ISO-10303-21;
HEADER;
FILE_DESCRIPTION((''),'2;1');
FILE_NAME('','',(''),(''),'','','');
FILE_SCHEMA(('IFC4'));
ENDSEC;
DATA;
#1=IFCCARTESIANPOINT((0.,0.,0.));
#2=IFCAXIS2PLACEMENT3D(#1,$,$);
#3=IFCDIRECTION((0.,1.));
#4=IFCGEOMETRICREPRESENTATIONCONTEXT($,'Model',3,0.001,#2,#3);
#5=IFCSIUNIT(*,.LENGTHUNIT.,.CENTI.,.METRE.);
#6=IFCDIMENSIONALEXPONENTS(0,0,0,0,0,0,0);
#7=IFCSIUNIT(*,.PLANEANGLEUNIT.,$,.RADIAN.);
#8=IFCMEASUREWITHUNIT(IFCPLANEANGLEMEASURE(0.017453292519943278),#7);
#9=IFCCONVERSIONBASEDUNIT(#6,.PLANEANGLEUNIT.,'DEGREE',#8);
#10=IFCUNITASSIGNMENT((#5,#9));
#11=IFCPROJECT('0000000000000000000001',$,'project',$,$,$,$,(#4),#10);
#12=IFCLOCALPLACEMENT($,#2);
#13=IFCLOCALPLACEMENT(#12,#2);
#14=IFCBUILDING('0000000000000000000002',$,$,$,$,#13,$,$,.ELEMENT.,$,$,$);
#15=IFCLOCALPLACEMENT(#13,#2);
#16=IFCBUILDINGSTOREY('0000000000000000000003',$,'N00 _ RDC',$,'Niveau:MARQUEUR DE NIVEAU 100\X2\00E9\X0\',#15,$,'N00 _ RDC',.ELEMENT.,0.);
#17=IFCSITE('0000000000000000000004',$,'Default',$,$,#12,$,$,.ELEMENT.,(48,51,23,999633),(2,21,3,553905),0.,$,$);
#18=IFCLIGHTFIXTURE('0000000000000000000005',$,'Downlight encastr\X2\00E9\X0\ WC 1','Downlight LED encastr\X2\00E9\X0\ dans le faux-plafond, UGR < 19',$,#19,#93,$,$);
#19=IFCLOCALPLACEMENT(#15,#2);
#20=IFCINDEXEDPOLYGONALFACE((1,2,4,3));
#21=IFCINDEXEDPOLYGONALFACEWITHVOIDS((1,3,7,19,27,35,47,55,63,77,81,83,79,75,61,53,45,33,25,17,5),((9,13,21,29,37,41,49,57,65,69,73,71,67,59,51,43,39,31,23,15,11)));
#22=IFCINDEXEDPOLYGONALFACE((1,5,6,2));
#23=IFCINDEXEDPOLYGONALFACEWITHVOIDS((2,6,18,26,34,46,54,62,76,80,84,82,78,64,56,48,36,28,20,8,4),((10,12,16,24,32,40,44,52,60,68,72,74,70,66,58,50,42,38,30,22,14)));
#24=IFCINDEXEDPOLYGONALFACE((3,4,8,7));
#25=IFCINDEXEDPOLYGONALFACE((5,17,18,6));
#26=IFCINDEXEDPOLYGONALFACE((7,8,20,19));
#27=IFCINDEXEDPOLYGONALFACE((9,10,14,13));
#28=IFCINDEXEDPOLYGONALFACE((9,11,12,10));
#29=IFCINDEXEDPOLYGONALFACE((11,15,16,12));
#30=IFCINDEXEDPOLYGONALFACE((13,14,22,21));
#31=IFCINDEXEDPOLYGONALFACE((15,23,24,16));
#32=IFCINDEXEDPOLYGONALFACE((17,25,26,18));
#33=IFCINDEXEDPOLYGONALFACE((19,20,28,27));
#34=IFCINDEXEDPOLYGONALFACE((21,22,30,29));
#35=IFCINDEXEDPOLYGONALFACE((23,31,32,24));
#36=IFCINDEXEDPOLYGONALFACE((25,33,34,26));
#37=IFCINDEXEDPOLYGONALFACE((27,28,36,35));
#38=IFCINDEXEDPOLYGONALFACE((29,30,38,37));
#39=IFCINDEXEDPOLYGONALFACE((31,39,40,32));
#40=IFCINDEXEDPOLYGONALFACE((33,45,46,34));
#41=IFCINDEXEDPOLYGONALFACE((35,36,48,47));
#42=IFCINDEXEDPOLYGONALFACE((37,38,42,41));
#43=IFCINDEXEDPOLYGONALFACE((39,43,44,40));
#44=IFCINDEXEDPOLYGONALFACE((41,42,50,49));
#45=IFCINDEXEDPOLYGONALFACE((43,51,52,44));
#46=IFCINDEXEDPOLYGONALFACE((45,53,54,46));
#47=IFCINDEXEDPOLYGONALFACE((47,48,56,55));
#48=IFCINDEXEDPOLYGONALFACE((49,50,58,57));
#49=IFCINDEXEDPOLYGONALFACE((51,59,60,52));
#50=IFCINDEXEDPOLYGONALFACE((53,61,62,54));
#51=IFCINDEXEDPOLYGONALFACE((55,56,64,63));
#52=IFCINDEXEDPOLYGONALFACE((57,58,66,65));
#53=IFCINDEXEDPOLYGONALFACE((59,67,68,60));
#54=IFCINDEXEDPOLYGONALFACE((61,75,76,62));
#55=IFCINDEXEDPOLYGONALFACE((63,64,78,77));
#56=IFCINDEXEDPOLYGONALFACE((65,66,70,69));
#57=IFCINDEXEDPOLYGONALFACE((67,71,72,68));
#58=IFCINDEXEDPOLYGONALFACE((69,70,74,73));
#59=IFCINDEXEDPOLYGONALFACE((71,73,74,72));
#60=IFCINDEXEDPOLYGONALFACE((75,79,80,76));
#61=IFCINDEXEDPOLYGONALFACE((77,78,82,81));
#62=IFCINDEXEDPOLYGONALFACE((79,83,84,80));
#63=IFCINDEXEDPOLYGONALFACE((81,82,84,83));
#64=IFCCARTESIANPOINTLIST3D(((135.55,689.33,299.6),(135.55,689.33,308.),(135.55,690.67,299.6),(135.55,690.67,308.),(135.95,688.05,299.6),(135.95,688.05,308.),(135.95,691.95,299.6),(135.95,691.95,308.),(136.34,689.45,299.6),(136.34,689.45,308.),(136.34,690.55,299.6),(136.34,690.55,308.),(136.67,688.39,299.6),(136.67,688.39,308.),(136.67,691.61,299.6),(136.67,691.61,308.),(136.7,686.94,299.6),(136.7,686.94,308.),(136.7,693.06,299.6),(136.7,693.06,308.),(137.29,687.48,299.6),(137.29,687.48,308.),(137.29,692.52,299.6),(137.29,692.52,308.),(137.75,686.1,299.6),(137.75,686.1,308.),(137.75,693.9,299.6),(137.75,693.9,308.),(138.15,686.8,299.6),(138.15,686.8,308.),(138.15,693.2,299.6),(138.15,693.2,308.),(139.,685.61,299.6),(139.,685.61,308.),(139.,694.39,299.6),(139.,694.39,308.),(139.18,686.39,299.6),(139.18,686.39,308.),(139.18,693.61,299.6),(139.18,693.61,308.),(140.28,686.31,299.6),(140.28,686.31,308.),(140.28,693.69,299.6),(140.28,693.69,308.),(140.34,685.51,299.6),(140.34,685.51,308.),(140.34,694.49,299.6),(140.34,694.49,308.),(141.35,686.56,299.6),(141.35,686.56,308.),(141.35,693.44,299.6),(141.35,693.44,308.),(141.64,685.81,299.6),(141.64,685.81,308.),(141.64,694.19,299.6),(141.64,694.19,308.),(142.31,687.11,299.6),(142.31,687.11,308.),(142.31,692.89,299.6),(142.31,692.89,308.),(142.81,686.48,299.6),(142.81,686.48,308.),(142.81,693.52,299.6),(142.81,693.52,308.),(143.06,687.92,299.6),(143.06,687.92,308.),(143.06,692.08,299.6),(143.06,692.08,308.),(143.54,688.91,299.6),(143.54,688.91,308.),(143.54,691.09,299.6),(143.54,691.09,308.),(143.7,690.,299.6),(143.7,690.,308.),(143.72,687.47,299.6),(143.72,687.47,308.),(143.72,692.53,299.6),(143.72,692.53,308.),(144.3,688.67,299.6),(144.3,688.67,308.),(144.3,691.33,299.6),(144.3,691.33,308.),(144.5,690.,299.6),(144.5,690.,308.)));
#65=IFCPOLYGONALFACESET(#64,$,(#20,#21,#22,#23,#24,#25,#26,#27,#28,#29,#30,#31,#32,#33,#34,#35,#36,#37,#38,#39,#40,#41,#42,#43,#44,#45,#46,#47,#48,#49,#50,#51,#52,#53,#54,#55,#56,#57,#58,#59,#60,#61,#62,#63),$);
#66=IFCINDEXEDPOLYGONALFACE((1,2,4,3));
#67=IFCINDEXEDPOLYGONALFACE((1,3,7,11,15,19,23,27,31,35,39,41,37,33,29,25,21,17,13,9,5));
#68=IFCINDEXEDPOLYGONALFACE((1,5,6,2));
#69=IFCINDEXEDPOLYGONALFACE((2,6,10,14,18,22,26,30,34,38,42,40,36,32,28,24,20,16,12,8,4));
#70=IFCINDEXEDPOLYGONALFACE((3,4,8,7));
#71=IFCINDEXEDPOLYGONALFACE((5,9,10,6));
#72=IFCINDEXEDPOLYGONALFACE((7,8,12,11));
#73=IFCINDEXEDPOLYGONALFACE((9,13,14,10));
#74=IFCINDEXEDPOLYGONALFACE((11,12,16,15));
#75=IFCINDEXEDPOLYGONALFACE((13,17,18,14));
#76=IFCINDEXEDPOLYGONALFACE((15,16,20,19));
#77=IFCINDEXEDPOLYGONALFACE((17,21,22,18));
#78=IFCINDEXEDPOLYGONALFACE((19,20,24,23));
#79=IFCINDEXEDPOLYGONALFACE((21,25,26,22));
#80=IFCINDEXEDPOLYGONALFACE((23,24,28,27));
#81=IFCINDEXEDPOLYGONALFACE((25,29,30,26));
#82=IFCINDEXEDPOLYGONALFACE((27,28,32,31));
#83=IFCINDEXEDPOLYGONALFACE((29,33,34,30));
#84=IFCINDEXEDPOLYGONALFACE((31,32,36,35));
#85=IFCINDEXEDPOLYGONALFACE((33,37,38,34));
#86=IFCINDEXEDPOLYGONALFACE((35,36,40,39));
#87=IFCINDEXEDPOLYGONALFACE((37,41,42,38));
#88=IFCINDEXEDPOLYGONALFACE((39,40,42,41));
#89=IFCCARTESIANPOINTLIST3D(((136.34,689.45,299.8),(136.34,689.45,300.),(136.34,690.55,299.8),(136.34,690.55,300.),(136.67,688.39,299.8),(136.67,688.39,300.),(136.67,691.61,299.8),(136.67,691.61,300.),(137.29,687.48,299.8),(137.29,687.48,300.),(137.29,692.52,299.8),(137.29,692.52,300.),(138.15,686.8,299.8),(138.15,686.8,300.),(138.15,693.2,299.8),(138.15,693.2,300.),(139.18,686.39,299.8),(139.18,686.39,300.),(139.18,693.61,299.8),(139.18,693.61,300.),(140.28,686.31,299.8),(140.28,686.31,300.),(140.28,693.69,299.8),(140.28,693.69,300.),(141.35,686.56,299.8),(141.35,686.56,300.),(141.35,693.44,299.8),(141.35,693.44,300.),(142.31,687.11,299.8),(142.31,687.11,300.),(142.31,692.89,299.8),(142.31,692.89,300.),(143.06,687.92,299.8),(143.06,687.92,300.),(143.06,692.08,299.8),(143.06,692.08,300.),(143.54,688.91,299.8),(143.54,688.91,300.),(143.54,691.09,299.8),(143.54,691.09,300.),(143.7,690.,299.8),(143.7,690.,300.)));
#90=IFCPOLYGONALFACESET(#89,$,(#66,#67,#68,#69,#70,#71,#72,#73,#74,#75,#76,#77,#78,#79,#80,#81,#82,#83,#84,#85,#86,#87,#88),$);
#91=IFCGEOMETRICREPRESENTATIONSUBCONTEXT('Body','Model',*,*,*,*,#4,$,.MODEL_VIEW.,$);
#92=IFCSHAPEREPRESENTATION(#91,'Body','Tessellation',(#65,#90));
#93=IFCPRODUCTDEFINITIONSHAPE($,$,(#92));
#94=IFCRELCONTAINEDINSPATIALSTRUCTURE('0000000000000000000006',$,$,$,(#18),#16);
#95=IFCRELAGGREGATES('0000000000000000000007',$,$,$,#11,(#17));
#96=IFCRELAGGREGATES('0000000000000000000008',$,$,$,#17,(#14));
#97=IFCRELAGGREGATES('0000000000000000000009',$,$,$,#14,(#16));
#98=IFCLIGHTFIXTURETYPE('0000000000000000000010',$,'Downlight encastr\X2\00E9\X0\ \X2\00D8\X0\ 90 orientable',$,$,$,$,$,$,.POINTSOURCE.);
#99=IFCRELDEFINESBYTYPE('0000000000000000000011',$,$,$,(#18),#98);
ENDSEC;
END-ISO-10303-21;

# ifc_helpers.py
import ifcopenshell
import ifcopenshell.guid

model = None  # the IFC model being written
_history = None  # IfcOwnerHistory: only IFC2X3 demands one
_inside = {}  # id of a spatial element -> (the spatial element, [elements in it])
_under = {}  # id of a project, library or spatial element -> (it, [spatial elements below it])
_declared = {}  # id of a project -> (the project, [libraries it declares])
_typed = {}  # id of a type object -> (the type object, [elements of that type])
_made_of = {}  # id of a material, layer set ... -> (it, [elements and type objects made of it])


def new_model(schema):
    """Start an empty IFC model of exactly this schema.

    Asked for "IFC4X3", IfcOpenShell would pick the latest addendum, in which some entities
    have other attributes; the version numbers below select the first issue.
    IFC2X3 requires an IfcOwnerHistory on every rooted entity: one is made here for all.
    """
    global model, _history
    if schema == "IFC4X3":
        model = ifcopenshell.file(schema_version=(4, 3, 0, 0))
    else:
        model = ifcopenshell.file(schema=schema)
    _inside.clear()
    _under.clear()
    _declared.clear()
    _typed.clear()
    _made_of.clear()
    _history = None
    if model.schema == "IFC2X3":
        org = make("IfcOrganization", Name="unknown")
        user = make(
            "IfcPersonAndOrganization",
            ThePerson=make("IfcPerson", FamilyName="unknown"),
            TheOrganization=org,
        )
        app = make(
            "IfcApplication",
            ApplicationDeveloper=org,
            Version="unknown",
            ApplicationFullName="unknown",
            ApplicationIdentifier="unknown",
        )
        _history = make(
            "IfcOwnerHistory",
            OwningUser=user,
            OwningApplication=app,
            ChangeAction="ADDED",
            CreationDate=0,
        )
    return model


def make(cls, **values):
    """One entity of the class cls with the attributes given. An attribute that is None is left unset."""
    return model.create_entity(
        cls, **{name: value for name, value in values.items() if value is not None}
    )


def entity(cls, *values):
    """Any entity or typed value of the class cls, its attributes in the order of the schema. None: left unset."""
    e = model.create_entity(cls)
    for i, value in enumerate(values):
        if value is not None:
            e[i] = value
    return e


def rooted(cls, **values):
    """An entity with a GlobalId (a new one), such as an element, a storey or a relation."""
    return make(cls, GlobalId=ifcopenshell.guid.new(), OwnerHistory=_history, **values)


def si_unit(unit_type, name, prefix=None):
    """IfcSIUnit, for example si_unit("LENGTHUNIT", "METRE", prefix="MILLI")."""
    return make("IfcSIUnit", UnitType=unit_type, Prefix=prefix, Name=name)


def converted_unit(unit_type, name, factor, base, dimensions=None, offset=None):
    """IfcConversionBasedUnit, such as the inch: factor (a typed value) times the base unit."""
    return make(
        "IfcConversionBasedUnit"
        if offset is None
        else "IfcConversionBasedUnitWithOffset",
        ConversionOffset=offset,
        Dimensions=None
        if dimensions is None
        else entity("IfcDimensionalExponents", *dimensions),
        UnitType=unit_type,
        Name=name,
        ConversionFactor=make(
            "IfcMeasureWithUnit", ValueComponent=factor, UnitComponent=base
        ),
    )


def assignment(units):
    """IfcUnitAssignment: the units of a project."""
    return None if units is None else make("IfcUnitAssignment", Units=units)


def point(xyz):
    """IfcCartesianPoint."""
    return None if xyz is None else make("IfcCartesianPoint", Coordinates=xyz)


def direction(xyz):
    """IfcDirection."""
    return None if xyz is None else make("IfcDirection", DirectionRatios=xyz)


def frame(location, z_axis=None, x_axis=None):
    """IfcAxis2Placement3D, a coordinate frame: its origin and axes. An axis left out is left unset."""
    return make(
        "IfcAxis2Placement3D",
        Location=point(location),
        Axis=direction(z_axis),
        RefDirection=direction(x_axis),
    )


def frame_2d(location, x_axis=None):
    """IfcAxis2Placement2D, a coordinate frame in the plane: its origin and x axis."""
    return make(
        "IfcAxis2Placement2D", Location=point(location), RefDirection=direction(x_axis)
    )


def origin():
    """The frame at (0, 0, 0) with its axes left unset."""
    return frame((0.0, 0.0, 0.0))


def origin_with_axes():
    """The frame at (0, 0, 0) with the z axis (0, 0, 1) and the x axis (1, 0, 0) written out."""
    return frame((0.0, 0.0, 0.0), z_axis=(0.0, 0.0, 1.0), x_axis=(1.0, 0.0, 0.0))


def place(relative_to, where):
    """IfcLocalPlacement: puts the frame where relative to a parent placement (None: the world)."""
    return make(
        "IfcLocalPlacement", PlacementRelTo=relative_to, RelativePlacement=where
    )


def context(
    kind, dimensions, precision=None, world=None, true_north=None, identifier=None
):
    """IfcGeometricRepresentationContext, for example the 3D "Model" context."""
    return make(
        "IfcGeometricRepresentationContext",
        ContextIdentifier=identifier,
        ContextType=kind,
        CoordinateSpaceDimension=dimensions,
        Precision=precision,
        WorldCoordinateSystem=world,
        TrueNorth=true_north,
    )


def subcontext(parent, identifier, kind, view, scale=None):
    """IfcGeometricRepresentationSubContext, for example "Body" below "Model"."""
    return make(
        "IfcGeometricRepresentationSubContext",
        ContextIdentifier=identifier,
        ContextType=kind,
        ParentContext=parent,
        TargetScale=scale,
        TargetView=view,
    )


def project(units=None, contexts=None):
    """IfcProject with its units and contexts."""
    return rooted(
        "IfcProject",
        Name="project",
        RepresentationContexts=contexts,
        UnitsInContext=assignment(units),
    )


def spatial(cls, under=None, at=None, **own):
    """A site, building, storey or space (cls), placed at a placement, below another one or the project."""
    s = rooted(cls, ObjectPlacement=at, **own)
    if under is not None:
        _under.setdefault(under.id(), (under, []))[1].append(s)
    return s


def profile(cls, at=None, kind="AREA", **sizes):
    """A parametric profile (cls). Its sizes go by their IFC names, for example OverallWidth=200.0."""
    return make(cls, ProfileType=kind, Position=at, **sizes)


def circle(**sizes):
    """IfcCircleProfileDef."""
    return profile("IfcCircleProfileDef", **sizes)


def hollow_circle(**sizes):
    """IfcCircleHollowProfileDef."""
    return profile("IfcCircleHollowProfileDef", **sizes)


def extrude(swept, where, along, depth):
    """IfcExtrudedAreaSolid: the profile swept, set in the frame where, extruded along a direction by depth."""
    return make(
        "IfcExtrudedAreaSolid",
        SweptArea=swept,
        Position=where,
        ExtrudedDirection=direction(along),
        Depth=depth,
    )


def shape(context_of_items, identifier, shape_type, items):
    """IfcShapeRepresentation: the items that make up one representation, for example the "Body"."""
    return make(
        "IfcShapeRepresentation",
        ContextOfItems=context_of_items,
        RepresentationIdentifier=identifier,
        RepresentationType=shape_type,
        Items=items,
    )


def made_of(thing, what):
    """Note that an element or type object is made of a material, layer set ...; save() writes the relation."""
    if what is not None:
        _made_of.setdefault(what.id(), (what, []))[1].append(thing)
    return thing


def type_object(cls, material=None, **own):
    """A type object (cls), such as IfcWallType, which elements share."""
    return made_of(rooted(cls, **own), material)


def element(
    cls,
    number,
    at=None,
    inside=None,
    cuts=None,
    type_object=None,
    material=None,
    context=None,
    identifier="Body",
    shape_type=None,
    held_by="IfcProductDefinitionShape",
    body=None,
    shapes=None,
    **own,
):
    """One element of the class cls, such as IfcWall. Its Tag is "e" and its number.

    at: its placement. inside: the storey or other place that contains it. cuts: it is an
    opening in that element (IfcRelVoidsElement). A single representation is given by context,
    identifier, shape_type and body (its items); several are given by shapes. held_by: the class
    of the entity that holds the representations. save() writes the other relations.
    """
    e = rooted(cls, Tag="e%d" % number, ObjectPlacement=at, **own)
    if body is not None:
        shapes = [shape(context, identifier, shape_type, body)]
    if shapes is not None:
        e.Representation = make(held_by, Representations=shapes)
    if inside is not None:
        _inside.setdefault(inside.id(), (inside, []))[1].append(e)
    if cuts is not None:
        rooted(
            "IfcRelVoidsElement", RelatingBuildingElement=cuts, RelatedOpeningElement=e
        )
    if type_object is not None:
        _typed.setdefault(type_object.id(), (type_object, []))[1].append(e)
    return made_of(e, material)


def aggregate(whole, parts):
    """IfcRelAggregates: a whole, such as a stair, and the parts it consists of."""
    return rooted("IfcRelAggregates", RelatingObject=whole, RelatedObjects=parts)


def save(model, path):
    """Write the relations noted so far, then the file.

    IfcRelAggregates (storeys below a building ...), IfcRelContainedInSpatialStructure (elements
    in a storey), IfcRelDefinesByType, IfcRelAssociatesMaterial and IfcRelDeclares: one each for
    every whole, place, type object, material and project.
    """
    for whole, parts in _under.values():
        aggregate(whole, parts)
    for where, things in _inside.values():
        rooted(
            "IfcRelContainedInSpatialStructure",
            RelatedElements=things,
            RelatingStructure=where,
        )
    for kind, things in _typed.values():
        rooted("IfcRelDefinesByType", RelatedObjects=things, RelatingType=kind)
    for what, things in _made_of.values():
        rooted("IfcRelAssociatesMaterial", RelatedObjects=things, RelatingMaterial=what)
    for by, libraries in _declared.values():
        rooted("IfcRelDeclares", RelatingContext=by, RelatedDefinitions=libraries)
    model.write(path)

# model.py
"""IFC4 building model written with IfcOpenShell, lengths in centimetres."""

from ifc_helpers import new_model, entity, si_unit, converted_unit, direction, frame, frame_2d, origin, origin_with_axes, place, context, subcontext, project, spatial, circle, hollow_circle, extrude, type_object, element, save


model = new_model("IFC4")

# Units and contexts
model_context = context("Model", 3, precision=0.001, world=origin(), true_north=direction((0.0, 1.0)))
body_context = subcontext(model_context, "Body", "Model", "MODEL_VIEW")
ifc_project = project(units=[si_unit("LENGTHUNIT", "METRE", prefix="CENTI"), converted_unit("PLANEANGLEUNIT", "DEGREE", entity("IfcPlaneAngleMeasure", 0.017453292519943278), si_unit("PLANEANGLEUNIT", "RADIAN"), dimensions=[0, 0, 0, 0, 0, 0, 0])], contexts=[model_context])

# Site, building, storey
site_placement = place(None, origin())
site = spatial("IfcSite", under=ifc_project, at=site_placement, Name="Default", CompositionType="ELEMENT", RefLatitude=(48, 51, 23, 999633), RefLongitude=(2, 21, 3, 553905), RefElevation=0.0)
building_placement = place(site_placement, origin())
building = spatial("IfcBuilding", under=site, at=building_placement, CompositionType="ELEMENT")
storey_placement = place(building_placement, origin())
storey = spatial("IfcBuildingStorey", under=building, at=storey_placement, Name="N00 _ RDC", ObjectType="Niveau:MARQUEUR DE NIVEAU 100é", LongName="N00 _ RDC", CompositionType="ELEMENT", Elevation=0.0)

# Light fixture
light_fixture_type_1 = type_object("IfcLightFixtureType", Name="Downlight encastré Ø 90 orientable", PredefinedType="POINTSOURCE")
light_fixture_1_placement = place(storey_placement, origin_with_axes())
element("IfcLightFixture", 1, at=light_fixture_1_placement, inside=storey, type_object=light_fixture_type_1, Name="Downlight encastré WC 1", Description="Downlight LED encastré dans le faux-plafond, UGR < 19", context=body_context, shape_type="SweptSolid", body=[
    extrude(hollow_circle(Radius=4.5, WallThickness=0.8, at=frame_2d((140.0, 690.0))), frame((0.0, 0.0, 299.6)), (0.0, 0.0, 1.0), 8.4),
    extrude(circle(Radius=3.7, at=frame_2d((140.0, 690.0))), frame((0.0, 0.0, 299.8)), (0.0, 0.0, 1.0), 0.2),
])

save(model, "model.ifc")
